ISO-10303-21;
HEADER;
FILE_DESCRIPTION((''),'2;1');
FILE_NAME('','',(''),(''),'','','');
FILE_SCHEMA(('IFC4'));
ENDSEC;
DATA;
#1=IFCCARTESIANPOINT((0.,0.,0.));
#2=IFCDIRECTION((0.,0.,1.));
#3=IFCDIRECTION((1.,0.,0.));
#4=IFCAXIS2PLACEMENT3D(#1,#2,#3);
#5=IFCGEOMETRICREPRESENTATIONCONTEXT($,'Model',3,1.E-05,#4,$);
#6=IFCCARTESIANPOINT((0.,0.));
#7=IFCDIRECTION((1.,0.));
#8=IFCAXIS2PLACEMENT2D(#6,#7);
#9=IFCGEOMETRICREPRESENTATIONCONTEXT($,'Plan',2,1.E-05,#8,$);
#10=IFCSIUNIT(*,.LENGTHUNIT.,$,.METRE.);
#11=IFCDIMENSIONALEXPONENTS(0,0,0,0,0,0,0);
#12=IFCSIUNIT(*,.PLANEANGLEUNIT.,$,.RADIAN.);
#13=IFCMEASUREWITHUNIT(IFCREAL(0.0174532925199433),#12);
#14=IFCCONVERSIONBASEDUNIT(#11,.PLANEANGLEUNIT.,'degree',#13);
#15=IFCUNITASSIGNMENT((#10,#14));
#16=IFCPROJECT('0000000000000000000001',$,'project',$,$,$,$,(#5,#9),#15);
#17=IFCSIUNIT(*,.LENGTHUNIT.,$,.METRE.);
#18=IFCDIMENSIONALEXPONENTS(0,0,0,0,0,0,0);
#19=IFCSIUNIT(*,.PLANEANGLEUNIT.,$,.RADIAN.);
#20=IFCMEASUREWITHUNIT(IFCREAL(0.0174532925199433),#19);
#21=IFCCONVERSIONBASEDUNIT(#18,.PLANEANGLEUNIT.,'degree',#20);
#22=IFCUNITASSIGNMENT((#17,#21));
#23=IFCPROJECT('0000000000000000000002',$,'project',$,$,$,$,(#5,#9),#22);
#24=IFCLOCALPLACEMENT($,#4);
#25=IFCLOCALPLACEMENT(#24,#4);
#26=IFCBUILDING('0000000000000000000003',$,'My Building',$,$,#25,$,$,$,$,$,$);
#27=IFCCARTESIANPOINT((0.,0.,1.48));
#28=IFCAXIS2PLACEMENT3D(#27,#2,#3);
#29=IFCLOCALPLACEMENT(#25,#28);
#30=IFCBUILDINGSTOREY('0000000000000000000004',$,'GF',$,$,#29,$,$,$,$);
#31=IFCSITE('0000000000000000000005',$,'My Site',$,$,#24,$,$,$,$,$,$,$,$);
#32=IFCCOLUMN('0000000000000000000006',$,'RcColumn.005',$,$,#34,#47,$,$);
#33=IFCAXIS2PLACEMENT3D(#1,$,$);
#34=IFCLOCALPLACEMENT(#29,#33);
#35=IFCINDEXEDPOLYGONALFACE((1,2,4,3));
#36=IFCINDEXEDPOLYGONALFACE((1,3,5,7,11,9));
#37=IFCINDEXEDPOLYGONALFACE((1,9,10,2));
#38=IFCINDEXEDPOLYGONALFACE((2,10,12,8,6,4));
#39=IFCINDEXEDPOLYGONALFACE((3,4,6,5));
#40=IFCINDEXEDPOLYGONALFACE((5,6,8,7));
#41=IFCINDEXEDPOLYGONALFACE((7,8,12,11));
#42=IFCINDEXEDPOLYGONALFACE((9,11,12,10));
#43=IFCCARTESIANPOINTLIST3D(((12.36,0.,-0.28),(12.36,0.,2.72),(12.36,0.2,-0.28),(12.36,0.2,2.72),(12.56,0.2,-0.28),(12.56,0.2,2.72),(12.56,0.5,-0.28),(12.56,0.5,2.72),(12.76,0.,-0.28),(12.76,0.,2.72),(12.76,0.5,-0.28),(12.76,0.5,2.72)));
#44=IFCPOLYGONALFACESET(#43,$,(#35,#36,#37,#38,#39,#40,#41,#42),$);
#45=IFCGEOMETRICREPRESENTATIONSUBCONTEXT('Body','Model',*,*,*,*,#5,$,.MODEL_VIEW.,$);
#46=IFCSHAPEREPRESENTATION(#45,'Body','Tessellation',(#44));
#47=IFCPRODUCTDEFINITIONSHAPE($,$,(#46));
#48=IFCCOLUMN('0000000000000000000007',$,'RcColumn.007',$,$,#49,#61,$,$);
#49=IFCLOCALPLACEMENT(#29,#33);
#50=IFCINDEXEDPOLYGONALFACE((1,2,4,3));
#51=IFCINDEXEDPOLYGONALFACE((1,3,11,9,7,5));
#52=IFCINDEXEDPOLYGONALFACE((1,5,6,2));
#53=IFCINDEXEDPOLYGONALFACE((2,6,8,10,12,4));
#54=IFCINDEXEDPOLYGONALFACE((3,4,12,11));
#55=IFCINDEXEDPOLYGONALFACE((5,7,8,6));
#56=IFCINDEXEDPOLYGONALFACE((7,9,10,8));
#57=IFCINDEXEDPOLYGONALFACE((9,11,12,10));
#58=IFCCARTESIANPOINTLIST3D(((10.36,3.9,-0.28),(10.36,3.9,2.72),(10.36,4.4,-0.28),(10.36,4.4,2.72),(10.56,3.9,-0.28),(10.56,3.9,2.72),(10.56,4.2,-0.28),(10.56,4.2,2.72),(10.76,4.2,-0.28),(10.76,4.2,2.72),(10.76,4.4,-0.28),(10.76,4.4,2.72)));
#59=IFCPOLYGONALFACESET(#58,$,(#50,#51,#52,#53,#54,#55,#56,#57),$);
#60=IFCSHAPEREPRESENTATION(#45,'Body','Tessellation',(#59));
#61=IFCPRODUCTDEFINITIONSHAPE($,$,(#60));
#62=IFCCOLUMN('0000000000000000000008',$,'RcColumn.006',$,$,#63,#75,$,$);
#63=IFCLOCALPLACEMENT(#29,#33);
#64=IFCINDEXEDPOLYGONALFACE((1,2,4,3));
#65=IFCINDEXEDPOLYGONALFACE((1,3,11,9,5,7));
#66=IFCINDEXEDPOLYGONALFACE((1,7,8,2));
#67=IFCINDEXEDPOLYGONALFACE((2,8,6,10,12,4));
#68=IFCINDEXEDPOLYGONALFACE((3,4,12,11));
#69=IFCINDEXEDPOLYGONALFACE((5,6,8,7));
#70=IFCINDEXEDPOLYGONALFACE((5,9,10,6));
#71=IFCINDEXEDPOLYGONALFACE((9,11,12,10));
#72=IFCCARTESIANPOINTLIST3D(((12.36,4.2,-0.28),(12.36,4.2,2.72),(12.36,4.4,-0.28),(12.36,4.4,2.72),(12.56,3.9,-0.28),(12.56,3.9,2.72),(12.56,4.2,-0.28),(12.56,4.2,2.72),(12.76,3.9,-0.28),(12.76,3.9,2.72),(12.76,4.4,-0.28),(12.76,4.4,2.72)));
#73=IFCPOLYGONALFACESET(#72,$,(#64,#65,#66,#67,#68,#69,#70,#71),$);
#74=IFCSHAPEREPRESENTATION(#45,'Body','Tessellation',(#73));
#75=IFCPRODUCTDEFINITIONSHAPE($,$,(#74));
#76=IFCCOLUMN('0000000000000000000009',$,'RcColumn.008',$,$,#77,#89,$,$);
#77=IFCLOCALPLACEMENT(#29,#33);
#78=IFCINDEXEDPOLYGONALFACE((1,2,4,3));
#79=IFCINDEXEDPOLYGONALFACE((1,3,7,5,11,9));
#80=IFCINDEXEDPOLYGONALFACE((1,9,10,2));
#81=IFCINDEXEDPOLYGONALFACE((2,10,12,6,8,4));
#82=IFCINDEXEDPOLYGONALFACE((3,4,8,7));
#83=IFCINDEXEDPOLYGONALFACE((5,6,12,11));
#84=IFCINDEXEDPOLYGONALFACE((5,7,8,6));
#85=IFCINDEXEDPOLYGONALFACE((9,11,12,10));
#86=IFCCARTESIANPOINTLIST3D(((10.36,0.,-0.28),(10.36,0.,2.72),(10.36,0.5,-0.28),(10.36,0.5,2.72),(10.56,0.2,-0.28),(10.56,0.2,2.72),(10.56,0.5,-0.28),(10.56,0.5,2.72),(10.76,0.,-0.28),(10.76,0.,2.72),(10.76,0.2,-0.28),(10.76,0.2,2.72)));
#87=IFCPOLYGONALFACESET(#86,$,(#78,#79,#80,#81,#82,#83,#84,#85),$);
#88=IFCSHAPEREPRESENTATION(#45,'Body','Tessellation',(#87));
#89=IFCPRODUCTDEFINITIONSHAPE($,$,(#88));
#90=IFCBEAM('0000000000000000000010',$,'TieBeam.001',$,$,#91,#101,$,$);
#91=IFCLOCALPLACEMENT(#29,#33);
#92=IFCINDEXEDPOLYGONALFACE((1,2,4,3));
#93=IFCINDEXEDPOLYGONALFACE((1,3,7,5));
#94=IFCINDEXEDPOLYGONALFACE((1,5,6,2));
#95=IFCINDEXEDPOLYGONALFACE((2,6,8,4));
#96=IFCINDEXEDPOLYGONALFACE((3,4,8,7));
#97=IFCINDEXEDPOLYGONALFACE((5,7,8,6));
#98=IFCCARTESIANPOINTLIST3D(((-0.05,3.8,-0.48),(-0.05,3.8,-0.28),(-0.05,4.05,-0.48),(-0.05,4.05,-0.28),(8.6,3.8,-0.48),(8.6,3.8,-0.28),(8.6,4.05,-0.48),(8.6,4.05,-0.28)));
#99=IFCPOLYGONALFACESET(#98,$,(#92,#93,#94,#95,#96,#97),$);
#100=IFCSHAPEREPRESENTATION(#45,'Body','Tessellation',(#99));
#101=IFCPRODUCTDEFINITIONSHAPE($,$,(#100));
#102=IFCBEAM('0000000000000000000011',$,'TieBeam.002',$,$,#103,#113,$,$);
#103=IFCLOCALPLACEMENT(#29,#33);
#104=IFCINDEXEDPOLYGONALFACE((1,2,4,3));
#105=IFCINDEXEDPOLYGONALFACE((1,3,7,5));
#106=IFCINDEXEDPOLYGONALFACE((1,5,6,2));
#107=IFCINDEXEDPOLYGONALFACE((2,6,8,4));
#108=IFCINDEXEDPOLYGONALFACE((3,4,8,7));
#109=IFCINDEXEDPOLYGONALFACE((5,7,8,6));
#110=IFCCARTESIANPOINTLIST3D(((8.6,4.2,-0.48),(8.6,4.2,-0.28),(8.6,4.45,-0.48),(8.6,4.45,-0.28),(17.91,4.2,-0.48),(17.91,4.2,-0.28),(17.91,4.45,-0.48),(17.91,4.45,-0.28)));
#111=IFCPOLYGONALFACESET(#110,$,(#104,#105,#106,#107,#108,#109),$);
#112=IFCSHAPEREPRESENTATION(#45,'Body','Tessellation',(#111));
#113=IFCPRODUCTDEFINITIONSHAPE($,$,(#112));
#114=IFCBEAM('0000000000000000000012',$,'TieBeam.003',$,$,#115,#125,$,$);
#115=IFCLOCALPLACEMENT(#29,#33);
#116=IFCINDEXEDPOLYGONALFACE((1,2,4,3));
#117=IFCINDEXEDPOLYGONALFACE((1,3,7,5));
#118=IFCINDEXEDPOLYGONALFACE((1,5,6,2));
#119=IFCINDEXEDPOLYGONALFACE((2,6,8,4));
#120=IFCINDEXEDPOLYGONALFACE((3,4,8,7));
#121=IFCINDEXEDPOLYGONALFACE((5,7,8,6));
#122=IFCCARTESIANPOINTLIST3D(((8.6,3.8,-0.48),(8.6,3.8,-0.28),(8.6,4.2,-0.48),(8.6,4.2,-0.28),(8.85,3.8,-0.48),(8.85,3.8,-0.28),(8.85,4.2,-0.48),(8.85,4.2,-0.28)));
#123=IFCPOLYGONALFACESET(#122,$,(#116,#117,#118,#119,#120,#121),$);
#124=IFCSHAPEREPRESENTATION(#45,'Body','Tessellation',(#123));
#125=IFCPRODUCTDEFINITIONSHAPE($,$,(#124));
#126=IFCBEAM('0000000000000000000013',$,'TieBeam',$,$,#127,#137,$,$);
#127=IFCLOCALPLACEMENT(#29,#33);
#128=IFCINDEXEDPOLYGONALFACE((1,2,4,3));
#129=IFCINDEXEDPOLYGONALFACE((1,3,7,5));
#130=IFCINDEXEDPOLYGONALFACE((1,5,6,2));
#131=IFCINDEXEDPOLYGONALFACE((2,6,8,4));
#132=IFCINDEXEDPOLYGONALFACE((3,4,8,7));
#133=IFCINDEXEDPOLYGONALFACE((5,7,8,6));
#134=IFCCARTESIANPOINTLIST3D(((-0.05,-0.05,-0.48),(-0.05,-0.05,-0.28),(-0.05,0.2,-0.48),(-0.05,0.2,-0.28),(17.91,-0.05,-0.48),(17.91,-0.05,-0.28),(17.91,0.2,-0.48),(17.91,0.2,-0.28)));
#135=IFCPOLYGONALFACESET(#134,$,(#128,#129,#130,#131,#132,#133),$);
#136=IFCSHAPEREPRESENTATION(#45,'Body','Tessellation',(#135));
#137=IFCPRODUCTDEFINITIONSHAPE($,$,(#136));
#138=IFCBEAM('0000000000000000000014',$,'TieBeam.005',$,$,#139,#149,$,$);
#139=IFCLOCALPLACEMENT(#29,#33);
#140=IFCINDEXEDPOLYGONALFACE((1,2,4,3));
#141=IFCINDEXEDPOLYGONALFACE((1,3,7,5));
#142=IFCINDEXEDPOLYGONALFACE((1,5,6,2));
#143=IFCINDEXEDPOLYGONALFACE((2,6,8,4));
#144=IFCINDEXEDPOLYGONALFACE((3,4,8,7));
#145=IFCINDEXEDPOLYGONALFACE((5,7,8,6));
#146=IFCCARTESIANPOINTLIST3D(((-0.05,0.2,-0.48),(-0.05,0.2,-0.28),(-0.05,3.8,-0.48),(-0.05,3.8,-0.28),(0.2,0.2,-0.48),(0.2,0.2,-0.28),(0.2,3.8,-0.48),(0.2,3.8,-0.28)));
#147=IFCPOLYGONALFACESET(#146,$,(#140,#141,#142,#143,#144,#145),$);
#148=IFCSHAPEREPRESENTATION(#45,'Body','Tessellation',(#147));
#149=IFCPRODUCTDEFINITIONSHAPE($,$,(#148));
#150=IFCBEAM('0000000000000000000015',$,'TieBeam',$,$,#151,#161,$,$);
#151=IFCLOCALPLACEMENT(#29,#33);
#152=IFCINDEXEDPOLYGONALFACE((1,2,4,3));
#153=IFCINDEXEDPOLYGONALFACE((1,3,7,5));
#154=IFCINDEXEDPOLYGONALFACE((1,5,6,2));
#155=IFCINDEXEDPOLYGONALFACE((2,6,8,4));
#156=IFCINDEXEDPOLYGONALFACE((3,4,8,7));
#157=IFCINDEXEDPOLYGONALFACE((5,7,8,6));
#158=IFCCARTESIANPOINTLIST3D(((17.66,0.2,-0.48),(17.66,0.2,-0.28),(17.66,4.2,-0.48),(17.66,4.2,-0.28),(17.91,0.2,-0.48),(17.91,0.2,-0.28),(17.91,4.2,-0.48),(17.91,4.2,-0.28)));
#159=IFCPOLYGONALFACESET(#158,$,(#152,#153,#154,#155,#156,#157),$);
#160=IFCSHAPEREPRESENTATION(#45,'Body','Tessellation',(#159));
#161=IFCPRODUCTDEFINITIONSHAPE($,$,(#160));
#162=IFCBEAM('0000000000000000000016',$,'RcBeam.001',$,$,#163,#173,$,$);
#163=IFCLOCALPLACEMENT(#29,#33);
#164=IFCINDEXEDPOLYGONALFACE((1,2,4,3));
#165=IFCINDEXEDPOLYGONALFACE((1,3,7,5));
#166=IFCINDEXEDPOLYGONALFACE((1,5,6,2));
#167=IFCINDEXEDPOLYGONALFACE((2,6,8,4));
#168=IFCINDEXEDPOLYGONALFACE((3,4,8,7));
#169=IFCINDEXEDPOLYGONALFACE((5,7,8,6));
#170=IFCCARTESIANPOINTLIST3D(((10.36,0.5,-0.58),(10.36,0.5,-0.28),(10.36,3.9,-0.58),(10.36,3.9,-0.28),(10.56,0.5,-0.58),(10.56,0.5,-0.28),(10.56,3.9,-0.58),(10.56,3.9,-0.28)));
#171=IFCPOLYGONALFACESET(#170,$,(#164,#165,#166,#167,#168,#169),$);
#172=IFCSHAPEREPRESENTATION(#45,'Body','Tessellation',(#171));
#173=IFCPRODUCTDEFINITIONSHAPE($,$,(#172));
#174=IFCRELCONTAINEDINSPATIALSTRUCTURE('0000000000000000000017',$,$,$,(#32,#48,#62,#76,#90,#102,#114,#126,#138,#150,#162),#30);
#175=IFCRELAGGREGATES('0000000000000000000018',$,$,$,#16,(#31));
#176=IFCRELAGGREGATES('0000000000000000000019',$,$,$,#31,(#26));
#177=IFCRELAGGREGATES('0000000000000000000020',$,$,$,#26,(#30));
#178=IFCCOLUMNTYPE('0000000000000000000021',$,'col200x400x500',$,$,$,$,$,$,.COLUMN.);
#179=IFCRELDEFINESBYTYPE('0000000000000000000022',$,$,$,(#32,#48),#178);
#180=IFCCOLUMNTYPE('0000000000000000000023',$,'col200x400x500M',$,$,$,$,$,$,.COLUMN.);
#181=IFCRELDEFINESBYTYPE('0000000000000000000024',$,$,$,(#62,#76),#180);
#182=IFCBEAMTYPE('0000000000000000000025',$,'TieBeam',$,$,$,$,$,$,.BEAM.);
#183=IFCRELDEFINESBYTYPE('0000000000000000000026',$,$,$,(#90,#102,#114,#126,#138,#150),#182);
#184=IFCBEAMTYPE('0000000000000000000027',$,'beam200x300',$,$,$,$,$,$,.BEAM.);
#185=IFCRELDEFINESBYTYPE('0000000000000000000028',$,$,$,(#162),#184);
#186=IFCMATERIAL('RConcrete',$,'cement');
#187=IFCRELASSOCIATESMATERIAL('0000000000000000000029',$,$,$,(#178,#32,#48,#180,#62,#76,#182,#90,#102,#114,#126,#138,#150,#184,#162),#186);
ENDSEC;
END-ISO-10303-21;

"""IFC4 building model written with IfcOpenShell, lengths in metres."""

from ifc_helpers import new_model, entity, si_unit, converted_unit, frame, origin_with_axes, origin_2d_with_axis, place, context, subcontext, project, spatial, line, indexed_curve, rectangle, outline, extrude, material, material_profile, profile_set, profile_usage, type_object, element, save


model = new_model("IFC4")

# Units and contexts
model_context = context("Model", 3, precision=1e-05, world=origin_with_axes())
plan_context = context("Plan", 2, precision=1e-05, world=origin_2d_with_axis())
body_context = subcontext(model_context, "Body", "Model", "MODEL_VIEW")
ifc_project_1 = project(units=[si_unit("LENGTHUNIT", "METRE"), converted_unit("PLANEANGLEUNIT", "degree", entity("IfcReal", 0.0174532925199433), si_unit("PLANEANGLEUNIT", "RADIAN"), dimensions=[0, 0, 0, 0, 0, 0, 0])], contexts=[model_context, plan_context])
ifc_project_2 = project(units=[si_unit("LENGTHUNIT", "METRE"), converted_unit("PLANEANGLEUNIT", "degree", entity("IfcReal", 0.0174532925199433), si_unit("PLANEANGLEUNIT", "RADIAN"), dimensions=[0, 0, 0, 0, 0, 0, 0])], contexts=[model_context, plan_context])

# Site, building, storey
site_placement = place(None, origin_with_axes())
site = spatial("IfcSite", under=ifc_project_1, at=site_placement, Name="My Site")
building_placement = place(site_placement, origin_with_axes())
building = spatial("IfcBuilding", under=site, at=building_placement, Name="My Building")
storey_placement = place(building_placement, frame((0.0, 0.0, 1.48), z_axis=(0.0, 0.0, 1.0), x_axis=(1.0, 0.0, 0.0)))
storey = spatial("IfcBuildingStorey", under=building, at=storey_placement, Name="GF")

# Columns
ifc_material_1 = material(Name="RConcrete", Category="cement")
ifc_material_profile_1 = material_profile(ifc_material_1, outline(indexed_curve([(0.2, 0.4), (0.2, 0.2), (0.5, 0.2), (0.5, 0.0), (0.0, 0.0), (0.0, 0.4)], segments=[line(6, 5), line(5, 4), line(4, 3), line(3, 2), line(2, 1), line(1, 6)], self_intersect=False)))
ifc_profile_set_1 = profile_set([ifc_material_profile_1], Name="RConcrete")
ifc_profile_usage_1 = profile_usage(ifc_profile_set_1, cardinal=5)
column_type_1 = type_object("IfcColumnType", Name="col200x400x500", PredefinedType="COLUMN", material=ifc_profile_set_1)
column_1_placement = place(storey_placement, frame((12.76, 0.0, -0.28), z_axis=(0.0, 0.0, 1.0), x_axis=(0.000001, 1.0, 0.0)))
element("IfcColumn", 1, at=column_1_placement, inside=storey, type_object=column_type_1, material=ifc_profile_usage_1, Name="RcColumn.005", context=body_context, shape_type="SweptSolid", body=[
    extrude(outline(indexed_curve([(0.2, 0.4), (0.2, 0.2), (0.5, 0.2), (0.5, 0.0), (0.0, 0.0), (0.0, 0.4)], segments=[line(6, 5), line(5, 4), line(4, 3), line(3, 2), line(2, 1), line(1, 6)], self_intersect=False)), origin_with_axes(), (0.0, 0.0, 1.0), 3.0),
])
ifc_profile_usage_2 = profile_usage(ifc_profile_set_1, cardinal=5)
column_2_placement = place(storey_placement, frame((10.36, 4.4, -0.28), z_axis=(0.0, 0.0, 1.0), x_axis=(0.0, -1.0, 0.0)))
element("IfcColumn", 2, at=column_2_placement, inside=storey, type_object=column_type_1, material=ifc_profile_usage_2, Name="RcColumn.007", context=body_context, shape_type="SweptSolid", body=[
    extrude(outline(indexed_curve([(0.2, 0.4), (0.2, 0.2), (0.5, 0.2), (0.5, 0.0), (0.0, 0.0), (0.0, 0.4)], segments=[line(6, 5), line(5, 4), line(4, 3), line(3, 2), line(2, 1), line(1, 6)], self_intersect=False)), origin_with_axes(), (0.0, 0.0, 1.0), 3.0),
])
ifc_material_profile_2 = material_profile(ifc_material_1, outline(indexed_curve([(0.0, 0.5), (0.0, 0.0), (0.4, 0.0), (0.4, 0.2), (0.2, 0.2), (0.2, 0.5)], segments=[line(5, 4), line(4, 3), line(3, 2), line(2, 1), line(1, 6), line(6, 5)], self_intersect=False)))
ifc_profile_set_2 = profile_set([ifc_material_profile_2], Name="RConcrete")
ifc_profile_usage_3 = profile_usage(ifc_profile_set_2, cardinal=5)
column_type_2 = type_object("IfcColumnType", Name="col200x400x500M", PredefinedType="COLUMN", material=ifc_profile_set_2)
column_3_placement = place(storey_placement, frame((12.76, 4.4, -0.28), z_axis=(0.0, 0.0, 1.0), x_axis=(-1.0, 0.0, 0.0)))
element("IfcColumn", 3, at=column_3_placement, inside=storey, type_object=column_type_2, material=ifc_profile_usage_3, Name="RcColumn.006", context=body_context, shape_type="SweptSolid", body=[
    extrude(outline(indexed_curve([(0.0, 0.5), (0.0, 0.0), (0.4, 0.0), (0.4, 0.2), (0.2, 0.2), (0.2, 0.5)], segments=[line(5, 4), line(4, 3), line(3, 2), line(2, 1), line(1, 6), line(6, 5)], self_intersect=False)), origin_with_axes(), (0.0, 0.0, 1.0), 3.0),
])
ifc_profile_usage_4 = profile_usage(ifc_profile_set_2, cardinal=5)
column_4_placement = place(storey_placement, frame((10.36, 0.0, -0.28), z_axis=(0.0, 0.0, 1.0), x_axis=(1.0, 0.0, 0.0)))
element("IfcColumn", 4, at=column_4_placement, inside=storey, type_object=column_type_2, material=ifc_profile_usage_4, Name="RcColumn.008", context=body_context, shape_type="SweptSolid", body=[
    extrude(outline(indexed_curve([(0.0, 0.5), (0.0, 0.0), (0.4, 0.0), (0.4, 0.2), (0.2, 0.2), (0.2, 0.5)], segments=[line(5, 4), line(4, 3), line(3, 2), line(2, 1), line(1, 6), line(6, 5)], self_intersect=False)), origin_with_axes(), (0.0, 0.0, 1.0), 3.0),
])

# Beams
ifc_material_profile_3 = material_profile(ifc_material_1, rectangle(XDim=0.25, YDim=0.2))
ifc_profile_set_3 = profile_set([ifc_material_profile_3], Name="RConcrete")
ifc_profile_usage_5 = profile_usage(ifc_profile_set_3, cardinal=1)
beam_type_1 = type_object("IfcBeamType", Name="TieBeam", PredefinedType="BEAM", material=ifc_profile_set_3)
beam_1_placement = place(storey_placement, frame((-0.05, 4.05, -0.48), z_axis=(1.0, 0.0, 0.0), x_axis=(0.0, 1.0, 0.0)))
element("IfcBeam", 5, at=beam_1_placement, inside=storey, type_object=beam_type_1, material=ifc_profile_usage_5, Name="TieBeam.001", context=body_context, shape_type="SweptSolid", body=[
    extrude(rectangle(XDim=0.25, YDim=0.2), frame((-0.125, 0.1, 0.0), z_axis=(0.0, 0.0, 1.0), x_axis=(1.0, 0.0, 0.0)), (0.0, 0.0, 1.0), 8.65),
])
ifc_profile_usage_6 = profile_usage(ifc_profile_set_3, cardinal=1)
beam_2_placement = place(storey_placement, frame((8.6, 4.45, -0.48), z_axis=(1.0, 0.0, 0.0), x_axis=(0.0, 1.0, 0.0)))
element("IfcBeam", 6, at=beam_2_placement, inside=storey, type_object=beam_type_1, material=ifc_profile_usage_6, Name="TieBeam.002", context=body_context, shape_type="SweptSolid", body=[
    extrude(rectangle(XDim=0.25, YDim=0.2), frame((-0.125, 0.1, 0.0), z_axis=(0.0, 0.0, 1.0), x_axis=(1.0, 0.0, 0.0)), (0.0, 0.0, 1.0), 9.31),
])
ifc_profile_usage_7 = profile_usage(ifc_profile_set_3, cardinal=1)
beam_3_placement = place(storey_placement, frame((8.6, 3.8, -0.48), z_axis=(0.0, 1.0, 0.0), x_axis=(-1.0, 0.0, 0.0)))
element("IfcBeam", 7, at=beam_3_placement, inside=storey, type_object=beam_type_1, material=ifc_profile_usage_7, Name="TieBeam.003", context=body_context, shape_type="SweptSolid", body=[
    extrude(rectangle(XDim=0.25, YDim=0.2), frame((-0.125, 0.1, 0.0), z_axis=(0.0, 0.0, 1.0), x_axis=(1.0, 0.0, 0.0)), (0.0, 0.0, 1.0), 0.4),
])
ifc_profile_usage_8 = profile_usage(ifc_profile_set_3, cardinal=1)
beam_4_placement = place(storey_placement, frame((-0.05, 0.2, -0.48), z_axis=(1.0, 0.0, 0.0), x_axis=(0.0, 1.0, 0.0)))
element("IfcBeam", 8, at=beam_4_placement, inside=storey, type_object=beam_type_1, material=ifc_profile_usage_8, Name="TieBeam", context=body_context, shape_type="SweptSolid", body=[
    extrude(rectangle(XDim=0.25, YDim=0.2), frame((-0.125, 0.1, 0.0), z_axis=(0.0, 0.0, 1.0), x_axis=(1.0, 0.0, 0.0)), (0.0, 0.0, 1.0), 17.96),
])
ifc_profile_usage_9 = profile_usage(ifc_profile_set_3, cardinal=1)
beam_5_placement = place(storey_placement, frame((0.2, 3.8, -0.48), z_axis=(0.0, -1.0, 0.0), x_axis=(1.0, 0.0, 0.0)))
element("IfcBeam", 9, at=beam_5_placement, inside=storey, type_object=beam_type_1, material=ifc_profile_usage_9, Name="TieBeam.005", context=body_context, shape_type="SweptSolid", body=[
    extrude(rectangle(XDim=0.25, YDim=0.2), frame((-0.125, 0.1, 0.0), z_axis=(0.0, 0.0, 1.0), x_axis=(1.0, 0.0, 0.0)), (0.0, 0.0, 1.0), 3.6),
])
ifc_profile_usage_10 = profile_usage(ifc_profile_set_3, cardinal=1)
beam_6_placement = place(storey_placement, frame((17.91, 4.2, -0.48), z_axis=(0.0, -1.0, 0.0), x_axis=(1.0, 0.0, 0.0)))
element("IfcBeam", 10, at=beam_6_placement, inside=storey, type_object=beam_type_1, material=ifc_profile_usage_10, Name="TieBeam", context=body_context, shape_type="SweptSolid", body=[
    extrude(rectangle(XDim=0.25, YDim=0.2), frame((-0.125, 0.1, 0.0), z_axis=(0.0, 0.0, 1.0), x_axis=(1.0, 0.0, 0.0)), (0.0, 0.0, 1.0), 4.0),
])
ifc_material_profile_4 = material_profile(ifc_material_1, rectangle(XDim=0.2, YDim=0.3))
ifc_profile_set_4 = profile_set([ifc_material_profile_4], Name="RConcrete")
ifc_profile_usage_11 = profile_usage(ifc_profile_set_4, cardinal=1)
beam_type_2 = type_object("IfcBeamType", Name="beam200x300", PredefinedType="BEAM", material=ifc_profile_set_4)
beam_7_placement = place(storey_placement, frame((10.56, 3.9, -0.58), z_axis=(0.0, -1.0, 0.0), x_axis=(1.0, 0.0, 0.0)))
element("IfcBeam", 11, at=beam_7_placement, inside=storey, type_object=beam_type_2, material=ifc_profile_usage_11, Name="RcBeam.001", context=body_context, shape_type="SweptSolid", body=[
    extrude(rectangle(XDim=0.2, YDim=0.3), frame((-0.1, 0.15, 0.0), z_axis=(0.0, 0.0, 1.0), x_axis=(1.0, 0.0, 0.0)), (0.0, 0.0, 1.0), 3.4),
])

save(model, "model.ifc")
